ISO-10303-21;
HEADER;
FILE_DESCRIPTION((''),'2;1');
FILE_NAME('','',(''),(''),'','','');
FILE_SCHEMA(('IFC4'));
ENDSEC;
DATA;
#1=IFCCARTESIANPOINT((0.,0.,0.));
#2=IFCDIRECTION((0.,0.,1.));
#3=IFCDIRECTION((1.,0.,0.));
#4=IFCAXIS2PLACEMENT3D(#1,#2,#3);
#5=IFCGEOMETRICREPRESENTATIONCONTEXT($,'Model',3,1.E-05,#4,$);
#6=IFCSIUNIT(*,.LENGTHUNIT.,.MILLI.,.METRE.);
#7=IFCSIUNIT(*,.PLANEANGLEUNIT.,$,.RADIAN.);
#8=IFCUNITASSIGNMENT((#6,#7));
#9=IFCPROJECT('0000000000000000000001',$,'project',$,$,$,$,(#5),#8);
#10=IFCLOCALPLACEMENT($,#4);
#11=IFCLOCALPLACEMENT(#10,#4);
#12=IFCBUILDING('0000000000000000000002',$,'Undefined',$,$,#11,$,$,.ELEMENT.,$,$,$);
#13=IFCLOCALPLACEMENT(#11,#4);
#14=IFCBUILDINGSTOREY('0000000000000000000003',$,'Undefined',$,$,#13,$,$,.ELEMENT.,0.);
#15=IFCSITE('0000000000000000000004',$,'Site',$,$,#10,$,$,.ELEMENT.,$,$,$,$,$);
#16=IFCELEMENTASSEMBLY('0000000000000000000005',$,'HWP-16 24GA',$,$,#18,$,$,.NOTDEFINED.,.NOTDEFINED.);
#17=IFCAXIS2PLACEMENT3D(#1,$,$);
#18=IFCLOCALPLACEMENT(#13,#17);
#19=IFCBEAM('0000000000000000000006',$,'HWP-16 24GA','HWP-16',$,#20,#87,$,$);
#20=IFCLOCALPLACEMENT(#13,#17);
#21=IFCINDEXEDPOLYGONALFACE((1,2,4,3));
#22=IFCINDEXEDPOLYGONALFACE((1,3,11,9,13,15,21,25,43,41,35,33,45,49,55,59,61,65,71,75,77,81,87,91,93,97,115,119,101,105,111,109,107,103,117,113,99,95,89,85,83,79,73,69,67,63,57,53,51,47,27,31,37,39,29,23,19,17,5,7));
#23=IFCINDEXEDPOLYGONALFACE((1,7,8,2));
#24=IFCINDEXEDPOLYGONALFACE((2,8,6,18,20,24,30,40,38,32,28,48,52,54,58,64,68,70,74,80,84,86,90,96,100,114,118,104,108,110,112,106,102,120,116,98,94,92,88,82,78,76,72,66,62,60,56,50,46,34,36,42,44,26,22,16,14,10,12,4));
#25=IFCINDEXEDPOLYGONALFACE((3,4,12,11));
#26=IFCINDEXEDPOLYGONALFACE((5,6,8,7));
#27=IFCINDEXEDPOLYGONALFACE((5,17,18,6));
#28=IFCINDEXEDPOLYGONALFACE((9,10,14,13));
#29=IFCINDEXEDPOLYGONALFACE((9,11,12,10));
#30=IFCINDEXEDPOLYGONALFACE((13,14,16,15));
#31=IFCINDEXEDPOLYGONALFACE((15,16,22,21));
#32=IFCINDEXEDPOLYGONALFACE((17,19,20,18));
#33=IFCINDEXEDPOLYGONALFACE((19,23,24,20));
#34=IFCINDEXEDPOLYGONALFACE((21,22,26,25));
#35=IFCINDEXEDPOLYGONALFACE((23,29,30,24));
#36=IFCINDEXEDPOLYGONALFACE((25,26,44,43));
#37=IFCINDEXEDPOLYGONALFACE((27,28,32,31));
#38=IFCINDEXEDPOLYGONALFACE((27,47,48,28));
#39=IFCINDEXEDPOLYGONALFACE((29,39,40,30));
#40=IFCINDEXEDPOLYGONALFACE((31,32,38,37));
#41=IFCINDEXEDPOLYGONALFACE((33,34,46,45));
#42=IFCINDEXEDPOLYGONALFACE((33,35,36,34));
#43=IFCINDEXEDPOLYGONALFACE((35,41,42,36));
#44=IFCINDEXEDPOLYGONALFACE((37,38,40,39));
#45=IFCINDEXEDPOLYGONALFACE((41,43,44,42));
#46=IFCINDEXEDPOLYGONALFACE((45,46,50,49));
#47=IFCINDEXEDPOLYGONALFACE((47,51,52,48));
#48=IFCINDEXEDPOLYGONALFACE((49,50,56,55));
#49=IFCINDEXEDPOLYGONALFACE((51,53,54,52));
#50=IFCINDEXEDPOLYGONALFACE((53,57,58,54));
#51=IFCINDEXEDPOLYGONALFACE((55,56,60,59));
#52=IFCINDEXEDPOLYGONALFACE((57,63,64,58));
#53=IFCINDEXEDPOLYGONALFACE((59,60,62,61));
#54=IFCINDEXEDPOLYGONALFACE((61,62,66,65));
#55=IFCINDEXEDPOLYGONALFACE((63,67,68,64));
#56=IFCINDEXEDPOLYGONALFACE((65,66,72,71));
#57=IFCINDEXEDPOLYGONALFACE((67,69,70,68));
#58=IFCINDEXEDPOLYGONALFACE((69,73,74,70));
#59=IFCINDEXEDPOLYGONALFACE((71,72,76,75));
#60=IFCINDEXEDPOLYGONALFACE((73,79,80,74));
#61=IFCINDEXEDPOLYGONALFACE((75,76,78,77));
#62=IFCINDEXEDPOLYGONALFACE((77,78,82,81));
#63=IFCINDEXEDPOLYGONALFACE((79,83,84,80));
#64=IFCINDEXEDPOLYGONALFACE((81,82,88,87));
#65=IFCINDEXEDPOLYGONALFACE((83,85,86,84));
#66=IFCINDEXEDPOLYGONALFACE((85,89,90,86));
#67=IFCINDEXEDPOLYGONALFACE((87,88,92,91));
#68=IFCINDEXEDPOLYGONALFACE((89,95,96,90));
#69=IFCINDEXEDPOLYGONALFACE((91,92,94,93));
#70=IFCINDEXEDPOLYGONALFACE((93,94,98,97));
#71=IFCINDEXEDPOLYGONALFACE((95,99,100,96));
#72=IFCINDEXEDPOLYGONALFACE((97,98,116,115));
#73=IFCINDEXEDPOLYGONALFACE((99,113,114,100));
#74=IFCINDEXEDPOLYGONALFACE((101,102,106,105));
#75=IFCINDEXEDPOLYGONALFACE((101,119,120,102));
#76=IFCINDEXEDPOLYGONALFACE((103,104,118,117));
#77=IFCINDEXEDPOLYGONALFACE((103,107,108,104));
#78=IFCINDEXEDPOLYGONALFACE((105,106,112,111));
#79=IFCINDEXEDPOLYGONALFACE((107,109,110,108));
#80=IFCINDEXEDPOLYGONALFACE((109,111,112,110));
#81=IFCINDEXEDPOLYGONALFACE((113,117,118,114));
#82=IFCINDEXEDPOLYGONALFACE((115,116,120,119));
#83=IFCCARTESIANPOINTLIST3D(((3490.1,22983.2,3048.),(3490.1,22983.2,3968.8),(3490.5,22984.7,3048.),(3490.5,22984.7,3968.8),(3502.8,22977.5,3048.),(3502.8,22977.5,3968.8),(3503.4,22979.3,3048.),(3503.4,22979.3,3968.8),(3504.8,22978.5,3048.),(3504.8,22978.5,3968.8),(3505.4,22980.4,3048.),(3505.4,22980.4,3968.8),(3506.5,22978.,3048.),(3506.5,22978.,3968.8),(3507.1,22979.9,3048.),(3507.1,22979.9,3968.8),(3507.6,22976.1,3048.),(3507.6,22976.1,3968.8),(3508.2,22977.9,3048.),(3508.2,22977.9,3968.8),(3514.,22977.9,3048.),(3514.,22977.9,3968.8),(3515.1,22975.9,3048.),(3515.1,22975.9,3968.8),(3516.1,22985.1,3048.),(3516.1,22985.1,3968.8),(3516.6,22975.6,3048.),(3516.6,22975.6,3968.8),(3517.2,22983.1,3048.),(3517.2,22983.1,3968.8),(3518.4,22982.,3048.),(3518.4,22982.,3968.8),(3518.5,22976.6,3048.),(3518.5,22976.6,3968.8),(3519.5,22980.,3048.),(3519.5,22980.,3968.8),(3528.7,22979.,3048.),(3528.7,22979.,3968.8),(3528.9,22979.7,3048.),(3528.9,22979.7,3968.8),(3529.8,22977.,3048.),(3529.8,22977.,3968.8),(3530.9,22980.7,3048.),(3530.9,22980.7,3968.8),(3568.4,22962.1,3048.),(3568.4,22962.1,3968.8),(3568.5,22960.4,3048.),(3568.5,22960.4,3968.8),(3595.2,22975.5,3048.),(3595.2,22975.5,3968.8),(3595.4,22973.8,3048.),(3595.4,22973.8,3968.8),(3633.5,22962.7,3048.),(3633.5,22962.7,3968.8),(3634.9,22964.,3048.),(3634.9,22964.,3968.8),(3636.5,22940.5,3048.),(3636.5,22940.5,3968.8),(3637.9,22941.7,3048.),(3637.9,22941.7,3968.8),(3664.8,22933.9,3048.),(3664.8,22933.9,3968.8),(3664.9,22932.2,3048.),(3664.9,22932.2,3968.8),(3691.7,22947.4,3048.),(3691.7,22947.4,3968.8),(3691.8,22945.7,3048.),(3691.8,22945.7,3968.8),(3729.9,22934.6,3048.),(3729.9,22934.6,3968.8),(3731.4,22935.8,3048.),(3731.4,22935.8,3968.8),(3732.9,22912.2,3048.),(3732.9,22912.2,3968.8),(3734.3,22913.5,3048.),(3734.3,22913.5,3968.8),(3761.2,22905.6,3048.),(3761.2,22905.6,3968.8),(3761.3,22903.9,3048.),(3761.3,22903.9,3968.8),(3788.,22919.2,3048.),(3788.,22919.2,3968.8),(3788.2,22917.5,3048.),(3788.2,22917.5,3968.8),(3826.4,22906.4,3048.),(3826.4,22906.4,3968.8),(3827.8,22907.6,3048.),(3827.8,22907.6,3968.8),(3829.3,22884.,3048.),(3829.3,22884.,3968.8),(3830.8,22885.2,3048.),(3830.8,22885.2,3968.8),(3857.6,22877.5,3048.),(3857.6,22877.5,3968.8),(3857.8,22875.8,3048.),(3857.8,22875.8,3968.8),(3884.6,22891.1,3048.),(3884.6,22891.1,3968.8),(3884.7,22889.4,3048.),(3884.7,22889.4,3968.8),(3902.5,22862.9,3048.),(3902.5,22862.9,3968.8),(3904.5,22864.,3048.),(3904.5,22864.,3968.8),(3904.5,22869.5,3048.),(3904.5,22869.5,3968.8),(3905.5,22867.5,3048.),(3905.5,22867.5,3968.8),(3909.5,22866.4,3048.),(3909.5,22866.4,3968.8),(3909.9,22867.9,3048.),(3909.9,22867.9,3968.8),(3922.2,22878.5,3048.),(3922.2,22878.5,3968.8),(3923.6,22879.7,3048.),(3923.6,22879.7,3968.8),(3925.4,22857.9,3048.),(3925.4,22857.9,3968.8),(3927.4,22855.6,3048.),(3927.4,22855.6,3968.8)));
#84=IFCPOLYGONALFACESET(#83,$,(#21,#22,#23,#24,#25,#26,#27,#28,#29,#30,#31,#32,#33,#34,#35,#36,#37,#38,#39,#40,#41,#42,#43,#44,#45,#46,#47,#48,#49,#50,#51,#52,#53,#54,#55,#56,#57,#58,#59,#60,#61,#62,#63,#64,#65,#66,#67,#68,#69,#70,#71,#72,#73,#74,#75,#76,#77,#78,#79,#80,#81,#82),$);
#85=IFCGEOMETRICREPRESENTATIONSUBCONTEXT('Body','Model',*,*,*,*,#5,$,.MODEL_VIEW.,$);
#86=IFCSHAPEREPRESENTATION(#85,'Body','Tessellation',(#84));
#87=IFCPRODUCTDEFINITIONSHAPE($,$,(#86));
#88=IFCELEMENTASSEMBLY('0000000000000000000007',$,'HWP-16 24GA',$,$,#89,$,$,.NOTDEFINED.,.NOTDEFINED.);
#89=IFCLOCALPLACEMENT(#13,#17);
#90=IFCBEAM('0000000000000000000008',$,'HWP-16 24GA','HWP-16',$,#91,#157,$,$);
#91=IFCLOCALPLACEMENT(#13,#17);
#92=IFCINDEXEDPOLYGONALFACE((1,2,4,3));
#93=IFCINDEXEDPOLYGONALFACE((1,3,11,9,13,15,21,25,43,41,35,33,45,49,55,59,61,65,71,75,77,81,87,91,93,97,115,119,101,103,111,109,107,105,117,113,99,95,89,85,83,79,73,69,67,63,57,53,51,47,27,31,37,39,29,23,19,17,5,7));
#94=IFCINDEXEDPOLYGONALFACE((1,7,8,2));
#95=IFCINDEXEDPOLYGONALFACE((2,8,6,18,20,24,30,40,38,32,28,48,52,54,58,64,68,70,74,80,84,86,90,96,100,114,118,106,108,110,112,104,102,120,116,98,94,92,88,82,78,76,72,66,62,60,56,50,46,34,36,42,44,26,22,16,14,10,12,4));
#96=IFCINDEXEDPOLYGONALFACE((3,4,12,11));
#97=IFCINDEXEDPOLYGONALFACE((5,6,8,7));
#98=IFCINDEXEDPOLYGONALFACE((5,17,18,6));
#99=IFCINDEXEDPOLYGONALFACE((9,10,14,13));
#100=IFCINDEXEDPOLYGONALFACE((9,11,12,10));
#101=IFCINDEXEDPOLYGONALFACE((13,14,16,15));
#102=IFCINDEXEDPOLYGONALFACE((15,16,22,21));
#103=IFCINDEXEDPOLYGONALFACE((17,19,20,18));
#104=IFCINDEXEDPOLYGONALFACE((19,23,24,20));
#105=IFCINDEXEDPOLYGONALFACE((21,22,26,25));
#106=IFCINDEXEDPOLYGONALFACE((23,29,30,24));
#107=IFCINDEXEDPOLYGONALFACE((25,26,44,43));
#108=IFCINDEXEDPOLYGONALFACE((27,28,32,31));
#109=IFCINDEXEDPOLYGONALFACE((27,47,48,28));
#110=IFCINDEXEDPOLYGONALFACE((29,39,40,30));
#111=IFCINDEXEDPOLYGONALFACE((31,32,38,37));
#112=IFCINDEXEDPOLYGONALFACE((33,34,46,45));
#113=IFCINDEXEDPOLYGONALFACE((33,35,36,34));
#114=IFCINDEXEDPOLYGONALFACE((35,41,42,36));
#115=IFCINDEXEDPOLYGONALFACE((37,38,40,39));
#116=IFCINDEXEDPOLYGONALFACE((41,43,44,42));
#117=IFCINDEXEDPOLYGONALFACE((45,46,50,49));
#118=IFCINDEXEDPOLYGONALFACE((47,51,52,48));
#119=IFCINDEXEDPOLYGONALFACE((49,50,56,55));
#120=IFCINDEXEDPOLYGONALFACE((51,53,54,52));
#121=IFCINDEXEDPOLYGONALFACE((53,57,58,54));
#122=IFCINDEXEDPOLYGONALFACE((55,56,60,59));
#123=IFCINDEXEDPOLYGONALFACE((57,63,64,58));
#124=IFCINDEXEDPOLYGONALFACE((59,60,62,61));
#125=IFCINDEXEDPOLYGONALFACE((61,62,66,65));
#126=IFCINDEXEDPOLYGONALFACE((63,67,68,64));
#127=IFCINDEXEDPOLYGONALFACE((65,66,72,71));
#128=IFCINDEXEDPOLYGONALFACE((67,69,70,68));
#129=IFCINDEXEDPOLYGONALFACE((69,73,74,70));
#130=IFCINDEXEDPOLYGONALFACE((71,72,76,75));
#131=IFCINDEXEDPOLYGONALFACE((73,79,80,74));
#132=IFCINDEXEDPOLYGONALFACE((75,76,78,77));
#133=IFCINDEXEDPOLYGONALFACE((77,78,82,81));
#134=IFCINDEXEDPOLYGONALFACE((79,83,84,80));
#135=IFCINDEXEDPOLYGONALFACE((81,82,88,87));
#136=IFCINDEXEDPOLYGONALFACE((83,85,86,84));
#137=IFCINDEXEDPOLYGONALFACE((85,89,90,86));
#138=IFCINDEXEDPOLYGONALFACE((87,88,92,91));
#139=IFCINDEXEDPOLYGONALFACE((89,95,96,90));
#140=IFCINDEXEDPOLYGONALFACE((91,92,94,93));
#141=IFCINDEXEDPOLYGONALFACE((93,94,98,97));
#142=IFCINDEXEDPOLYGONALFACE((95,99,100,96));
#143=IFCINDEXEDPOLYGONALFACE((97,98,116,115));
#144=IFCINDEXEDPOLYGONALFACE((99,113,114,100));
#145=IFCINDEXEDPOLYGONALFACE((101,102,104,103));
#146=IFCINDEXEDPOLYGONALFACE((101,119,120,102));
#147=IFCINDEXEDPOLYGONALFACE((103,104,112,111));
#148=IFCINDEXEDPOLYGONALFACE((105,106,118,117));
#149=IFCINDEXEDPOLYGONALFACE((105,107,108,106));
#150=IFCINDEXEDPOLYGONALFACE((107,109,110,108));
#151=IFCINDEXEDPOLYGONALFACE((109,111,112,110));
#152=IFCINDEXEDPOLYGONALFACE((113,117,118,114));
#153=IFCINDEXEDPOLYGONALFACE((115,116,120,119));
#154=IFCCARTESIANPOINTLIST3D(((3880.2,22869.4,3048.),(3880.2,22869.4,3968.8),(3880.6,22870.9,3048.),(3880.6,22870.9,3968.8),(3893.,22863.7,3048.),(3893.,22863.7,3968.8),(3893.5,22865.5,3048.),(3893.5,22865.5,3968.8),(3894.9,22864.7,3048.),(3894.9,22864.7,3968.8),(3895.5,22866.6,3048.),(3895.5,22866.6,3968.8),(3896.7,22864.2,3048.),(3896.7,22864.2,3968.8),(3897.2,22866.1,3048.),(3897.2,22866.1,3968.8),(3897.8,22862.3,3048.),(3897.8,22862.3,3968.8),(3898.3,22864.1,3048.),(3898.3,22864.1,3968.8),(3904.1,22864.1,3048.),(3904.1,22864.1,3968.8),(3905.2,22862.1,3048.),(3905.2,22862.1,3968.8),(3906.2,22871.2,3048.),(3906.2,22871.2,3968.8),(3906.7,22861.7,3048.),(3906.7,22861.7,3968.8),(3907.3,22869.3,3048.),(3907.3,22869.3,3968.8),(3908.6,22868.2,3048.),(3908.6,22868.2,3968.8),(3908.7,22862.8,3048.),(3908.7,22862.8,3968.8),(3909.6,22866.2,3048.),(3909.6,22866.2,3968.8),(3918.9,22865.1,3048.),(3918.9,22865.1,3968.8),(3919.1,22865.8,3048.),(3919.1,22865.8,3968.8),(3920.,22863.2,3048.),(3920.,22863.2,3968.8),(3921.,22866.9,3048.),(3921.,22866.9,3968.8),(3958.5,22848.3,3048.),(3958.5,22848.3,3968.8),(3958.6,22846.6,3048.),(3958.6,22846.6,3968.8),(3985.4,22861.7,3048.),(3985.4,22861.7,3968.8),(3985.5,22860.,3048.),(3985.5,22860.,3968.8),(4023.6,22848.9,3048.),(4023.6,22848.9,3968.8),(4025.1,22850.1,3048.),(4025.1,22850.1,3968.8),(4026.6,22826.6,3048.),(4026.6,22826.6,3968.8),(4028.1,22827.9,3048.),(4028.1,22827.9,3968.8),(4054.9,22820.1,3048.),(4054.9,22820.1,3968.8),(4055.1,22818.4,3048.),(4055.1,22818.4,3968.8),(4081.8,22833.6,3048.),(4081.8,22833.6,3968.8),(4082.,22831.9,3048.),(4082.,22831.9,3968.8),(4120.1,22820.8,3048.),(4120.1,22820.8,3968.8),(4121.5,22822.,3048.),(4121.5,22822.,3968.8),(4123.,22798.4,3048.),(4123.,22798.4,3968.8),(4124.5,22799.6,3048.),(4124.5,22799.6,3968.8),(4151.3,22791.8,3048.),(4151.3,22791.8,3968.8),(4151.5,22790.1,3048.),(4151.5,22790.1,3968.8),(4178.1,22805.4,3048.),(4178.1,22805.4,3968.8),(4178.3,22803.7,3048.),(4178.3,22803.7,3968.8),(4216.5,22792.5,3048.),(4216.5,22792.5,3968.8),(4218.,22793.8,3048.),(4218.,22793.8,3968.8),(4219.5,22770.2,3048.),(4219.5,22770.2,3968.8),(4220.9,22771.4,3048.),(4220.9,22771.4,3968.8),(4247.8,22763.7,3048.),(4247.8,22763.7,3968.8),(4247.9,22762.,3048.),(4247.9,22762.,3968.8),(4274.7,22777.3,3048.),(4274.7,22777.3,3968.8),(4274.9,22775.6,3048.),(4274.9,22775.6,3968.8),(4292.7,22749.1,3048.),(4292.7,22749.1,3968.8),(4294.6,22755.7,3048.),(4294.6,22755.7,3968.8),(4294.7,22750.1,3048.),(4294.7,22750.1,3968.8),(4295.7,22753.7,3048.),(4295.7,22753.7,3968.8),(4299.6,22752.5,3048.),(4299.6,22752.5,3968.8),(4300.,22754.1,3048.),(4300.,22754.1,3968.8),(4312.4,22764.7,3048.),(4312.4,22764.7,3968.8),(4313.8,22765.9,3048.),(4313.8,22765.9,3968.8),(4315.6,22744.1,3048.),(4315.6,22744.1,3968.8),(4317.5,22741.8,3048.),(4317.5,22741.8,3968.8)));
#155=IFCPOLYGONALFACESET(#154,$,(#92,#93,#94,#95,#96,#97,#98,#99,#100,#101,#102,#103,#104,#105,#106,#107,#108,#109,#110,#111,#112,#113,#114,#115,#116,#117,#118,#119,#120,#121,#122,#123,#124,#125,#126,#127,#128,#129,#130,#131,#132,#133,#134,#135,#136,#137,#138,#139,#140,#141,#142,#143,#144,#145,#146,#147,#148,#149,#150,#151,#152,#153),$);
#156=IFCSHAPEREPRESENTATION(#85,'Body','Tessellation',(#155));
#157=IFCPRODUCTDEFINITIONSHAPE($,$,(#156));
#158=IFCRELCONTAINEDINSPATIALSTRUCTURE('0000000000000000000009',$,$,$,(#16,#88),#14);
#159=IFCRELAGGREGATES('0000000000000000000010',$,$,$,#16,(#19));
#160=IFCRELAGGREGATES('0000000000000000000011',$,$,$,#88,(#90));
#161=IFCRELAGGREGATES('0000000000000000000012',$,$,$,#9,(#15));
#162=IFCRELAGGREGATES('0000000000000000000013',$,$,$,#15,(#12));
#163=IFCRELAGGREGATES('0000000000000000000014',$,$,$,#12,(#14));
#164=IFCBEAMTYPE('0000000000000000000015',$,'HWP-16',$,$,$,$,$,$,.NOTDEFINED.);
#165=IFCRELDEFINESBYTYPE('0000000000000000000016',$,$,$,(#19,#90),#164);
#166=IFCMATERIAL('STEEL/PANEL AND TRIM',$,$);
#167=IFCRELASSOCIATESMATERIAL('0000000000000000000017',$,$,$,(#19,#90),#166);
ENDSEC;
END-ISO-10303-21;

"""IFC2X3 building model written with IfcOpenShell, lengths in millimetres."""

from ifc_helpers import new_model, si_unit, frame, origin_with_axes, place, context, subcontext, project, spatial, polyline, outline, extrude, boolean, material, type_object, element, aggregate, save


model = new_model("IFC2X3")

# Units and contexts
model_context = context("Model", 3, precision=1e-05, world=origin_with_axes())
body_context = subcontext(model_context, "Body", "Model", "MODEL_VIEW")
ifc_project = project(units=[si_unit("LENGTHUNIT", "METRE", prefix="MILLI"), si_unit("PLANEANGLEUNIT", "RADIAN")], contexts=[model_context])

# Site, building, storey
site_placement = place(None, origin_with_axes())
site = spatial("IfcSite", under=ifc_project, at=site_placement, Name="Site", CompositionType="ELEMENT")
building_placement = place(site_placement, origin_with_axes())
building = spatial("IfcBuilding", under=site, at=building_placement, Name="Undefined", CompositionType="ELEMENT")
storey_placement = place(building_placement, origin_with_axes())
storey = spatial("IfcBuildingStorey", under=building, at=storey_placement, Name="Undefined", CompositionType="ELEMENT", Elevation=0.0)

# Element assemblies, beams
ifc_material_1 = material(Name="STEEL/PANEL AND TRIM")
beam_type_1 = type_object("IfcBeamType", Name="HWP-16", PredefinedType="NOTDEFINED")
assembly_1_placement = place(storey_placement, origin_with_axes())
assembly_1 = element("IfcElementAssembly", 1, at=assembly_1_placement, inside=storey, Name="HWP-16 24GA", AssemblyPlace="NOTDEFINED", PredefinedType="NOTDEFINED")
beam_1_placement = place(assembly_1_placement, frame((3923.6, 22879.7, 3968.8), z_axis=(-0.280057, -0.959983, 0.0), x_axis=(0.0, 0.0, -1.0)))
beam_1 = element("IfcBeam", 2, at=beam_1_placement, type_object=beam_type_1, material=ifc_material_1, Name="HWP-16 24GA", Description="HWP-16", context=body_context, shape_type="CSG", body=[
    boolean("DIFFERENCE", extrude(outline(polyline([(40.7, 0.0), (0.0, 0.0), (-10.3, 22.1), (15.5, 22.1), (15.5, 15.2), (9.9, 15.2), (9.9, 16.8), (13.9, 16.8), (13.9, 20.5), (-7.8, 20.5), (1.0, 1.6), (40.1, 1.6), (62.1, 22.2), (91.7, 22.3), (100.8, 1.7), (140.6, 1.7), (162.6, 22.2), (192.2, 22.2), (201.3, 1.6), (241.0, 1.6), (263.1, 22.1), (292.7, 22.1), (301.8, 1.6), (341.5, 1.6), (363.5, 22.0), (417.6, 22.0), (417.6, 15.3), (406.9, 15.3), (406.9, 14.6), (419.2, 14.6), (419.2, 22.1), (426.4, 22.1), (426.4, 24.0), (431.3, 24.0), (431.3, 22.1), (445.2, 22.1), (445.2, 20.5), (429.7, 20.5), (429.7, 22.5), (427.9, 22.5), (427.9, 20.5), (420.7, 20.5), (420.7, 13.0), (405.3, 13.0), (405.3, 16.9), (416.0, 16.9), (416.0, 20.4), (364.1, 20.4), (342.1, 0.0), (300.7, 0.0), (291.6, 20.5), (263.7, 20.5), (241.6, 0.0), (200.3, 0.0), (191.2, 20.6), (163.2, 20.6), (141.3, 0.1), (99.8, 0.1), (90.7, 20.7), (62.7, 20.6), (40.7, 0.0)])), frame((1225.5, 0.0, 0.0), z_axis=(-1.0, 0.0, 0.0), x_axis=(0.0, -1.0, 0.0)), (0.0, 0.0, 1.0), 1225.5), extrude(outline(polyline([(0.0, 0.0), (5029.2, 0.0), (5029.2, 609.6), (0.0, 609.6), (0.0, 0.0)])), frame((920.8, 4013.2, -10.0), z_axis=(0.0, 0.0, 1.0), x_axis=(0.0, -1.0, 0.0)), (0.0, 0.0, 1.0), 44.0)),
])
aggregate(assembly_1, [beam_1])
assembly_2_placement = place(storey_placement, origin_with_axes())
assembly_2 = element("IfcElementAssembly", 3, at=assembly_2_placement, inside=storey, Name="HWP-16 24GA", AssemblyPlace="NOTDEFINED", PredefinedType="NOTDEFINED")
beam_2_placement = place(assembly_2_placement, frame((4313.8, 22765.9, 3968.8), z_axis=(-0.280057, -0.959983, 0.0), x_axis=(0.0, 0.0, -1.0)))
beam_2 = element("IfcBeam", 4, at=beam_2_placement, type_object=beam_type_1, material=ifc_material_1, Name="HWP-16 24GA", Description="HWP-16", context=body_context, shape_type="CSG", body=[
    boolean("DIFFERENCE", extrude(outline(polyline([(40.7, 0.0), (0.0, 0.0), (-10.3, 22.1), (15.5, 22.1), (15.5, 15.2), (9.9, 15.2), (9.9, 16.8), (13.9, 16.8), (13.9, 20.5), (-7.8, 20.5), (1.0, 1.6), (40.1, 1.6), (62.1, 22.2), (91.7, 22.3), (100.8, 1.7), (140.6, 1.7), (162.6, 22.2), (192.2, 22.2), (201.3, 1.6), (241.0, 1.6), (263.1, 22.1), (292.7, 22.1), (301.8, 1.6), (341.5, 1.6), (363.5, 22.0), (417.6, 22.0), (417.6, 15.3), (406.9, 15.3), (406.9, 14.6), (419.2, 14.6), (419.2, 22.1), (426.4, 22.1), (426.4, 24.0), (431.3, 24.0), (431.3, 22.1), (445.2, 22.1), (445.2, 20.5), (429.7, 20.5), (429.7, 22.5), (427.9, 22.5), (427.9, 20.5), (420.7, 20.5), (420.7, 13.0), (405.3, 13.0), (405.3, 16.9), (416.0, 16.9), (416.0, 20.4), (364.1, 20.4), (342.1, 0.0), (300.7, 0.0), (291.6, 20.5), (263.7, 20.5), (241.6, 0.0), (200.3, 0.0), (191.2, 20.6), (163.2, 20.6), (141.3, 0.1), (99.8, 0.1), (90.7, 20.7), (62.7, 20.6), (40.7, 0.0)])), frame((1225.5, 0.0, 0.0), z_axis=(-1.0, 0.0, 0.0), x_axis=(0.0, -1.0, 0.0)), (0.0, 0.0, 1.0), 1225.5), extrude(outline(polyline([(0.0, 0.0), (5029.2, 0.0), (5029.2, 609.6), (0.0, 609.6), (0.0, 0.0)])), frame((920.8, 3606.8, -10.0), z_axis=(0.0, 0.0, 1.0), x_axis=(0.0, -1.0, 0.0)), (0.0, 0.0, 1.0), 44.0)),
])
aggregate(assembly_2, [beam_2])

save(model, "model.ifc")
